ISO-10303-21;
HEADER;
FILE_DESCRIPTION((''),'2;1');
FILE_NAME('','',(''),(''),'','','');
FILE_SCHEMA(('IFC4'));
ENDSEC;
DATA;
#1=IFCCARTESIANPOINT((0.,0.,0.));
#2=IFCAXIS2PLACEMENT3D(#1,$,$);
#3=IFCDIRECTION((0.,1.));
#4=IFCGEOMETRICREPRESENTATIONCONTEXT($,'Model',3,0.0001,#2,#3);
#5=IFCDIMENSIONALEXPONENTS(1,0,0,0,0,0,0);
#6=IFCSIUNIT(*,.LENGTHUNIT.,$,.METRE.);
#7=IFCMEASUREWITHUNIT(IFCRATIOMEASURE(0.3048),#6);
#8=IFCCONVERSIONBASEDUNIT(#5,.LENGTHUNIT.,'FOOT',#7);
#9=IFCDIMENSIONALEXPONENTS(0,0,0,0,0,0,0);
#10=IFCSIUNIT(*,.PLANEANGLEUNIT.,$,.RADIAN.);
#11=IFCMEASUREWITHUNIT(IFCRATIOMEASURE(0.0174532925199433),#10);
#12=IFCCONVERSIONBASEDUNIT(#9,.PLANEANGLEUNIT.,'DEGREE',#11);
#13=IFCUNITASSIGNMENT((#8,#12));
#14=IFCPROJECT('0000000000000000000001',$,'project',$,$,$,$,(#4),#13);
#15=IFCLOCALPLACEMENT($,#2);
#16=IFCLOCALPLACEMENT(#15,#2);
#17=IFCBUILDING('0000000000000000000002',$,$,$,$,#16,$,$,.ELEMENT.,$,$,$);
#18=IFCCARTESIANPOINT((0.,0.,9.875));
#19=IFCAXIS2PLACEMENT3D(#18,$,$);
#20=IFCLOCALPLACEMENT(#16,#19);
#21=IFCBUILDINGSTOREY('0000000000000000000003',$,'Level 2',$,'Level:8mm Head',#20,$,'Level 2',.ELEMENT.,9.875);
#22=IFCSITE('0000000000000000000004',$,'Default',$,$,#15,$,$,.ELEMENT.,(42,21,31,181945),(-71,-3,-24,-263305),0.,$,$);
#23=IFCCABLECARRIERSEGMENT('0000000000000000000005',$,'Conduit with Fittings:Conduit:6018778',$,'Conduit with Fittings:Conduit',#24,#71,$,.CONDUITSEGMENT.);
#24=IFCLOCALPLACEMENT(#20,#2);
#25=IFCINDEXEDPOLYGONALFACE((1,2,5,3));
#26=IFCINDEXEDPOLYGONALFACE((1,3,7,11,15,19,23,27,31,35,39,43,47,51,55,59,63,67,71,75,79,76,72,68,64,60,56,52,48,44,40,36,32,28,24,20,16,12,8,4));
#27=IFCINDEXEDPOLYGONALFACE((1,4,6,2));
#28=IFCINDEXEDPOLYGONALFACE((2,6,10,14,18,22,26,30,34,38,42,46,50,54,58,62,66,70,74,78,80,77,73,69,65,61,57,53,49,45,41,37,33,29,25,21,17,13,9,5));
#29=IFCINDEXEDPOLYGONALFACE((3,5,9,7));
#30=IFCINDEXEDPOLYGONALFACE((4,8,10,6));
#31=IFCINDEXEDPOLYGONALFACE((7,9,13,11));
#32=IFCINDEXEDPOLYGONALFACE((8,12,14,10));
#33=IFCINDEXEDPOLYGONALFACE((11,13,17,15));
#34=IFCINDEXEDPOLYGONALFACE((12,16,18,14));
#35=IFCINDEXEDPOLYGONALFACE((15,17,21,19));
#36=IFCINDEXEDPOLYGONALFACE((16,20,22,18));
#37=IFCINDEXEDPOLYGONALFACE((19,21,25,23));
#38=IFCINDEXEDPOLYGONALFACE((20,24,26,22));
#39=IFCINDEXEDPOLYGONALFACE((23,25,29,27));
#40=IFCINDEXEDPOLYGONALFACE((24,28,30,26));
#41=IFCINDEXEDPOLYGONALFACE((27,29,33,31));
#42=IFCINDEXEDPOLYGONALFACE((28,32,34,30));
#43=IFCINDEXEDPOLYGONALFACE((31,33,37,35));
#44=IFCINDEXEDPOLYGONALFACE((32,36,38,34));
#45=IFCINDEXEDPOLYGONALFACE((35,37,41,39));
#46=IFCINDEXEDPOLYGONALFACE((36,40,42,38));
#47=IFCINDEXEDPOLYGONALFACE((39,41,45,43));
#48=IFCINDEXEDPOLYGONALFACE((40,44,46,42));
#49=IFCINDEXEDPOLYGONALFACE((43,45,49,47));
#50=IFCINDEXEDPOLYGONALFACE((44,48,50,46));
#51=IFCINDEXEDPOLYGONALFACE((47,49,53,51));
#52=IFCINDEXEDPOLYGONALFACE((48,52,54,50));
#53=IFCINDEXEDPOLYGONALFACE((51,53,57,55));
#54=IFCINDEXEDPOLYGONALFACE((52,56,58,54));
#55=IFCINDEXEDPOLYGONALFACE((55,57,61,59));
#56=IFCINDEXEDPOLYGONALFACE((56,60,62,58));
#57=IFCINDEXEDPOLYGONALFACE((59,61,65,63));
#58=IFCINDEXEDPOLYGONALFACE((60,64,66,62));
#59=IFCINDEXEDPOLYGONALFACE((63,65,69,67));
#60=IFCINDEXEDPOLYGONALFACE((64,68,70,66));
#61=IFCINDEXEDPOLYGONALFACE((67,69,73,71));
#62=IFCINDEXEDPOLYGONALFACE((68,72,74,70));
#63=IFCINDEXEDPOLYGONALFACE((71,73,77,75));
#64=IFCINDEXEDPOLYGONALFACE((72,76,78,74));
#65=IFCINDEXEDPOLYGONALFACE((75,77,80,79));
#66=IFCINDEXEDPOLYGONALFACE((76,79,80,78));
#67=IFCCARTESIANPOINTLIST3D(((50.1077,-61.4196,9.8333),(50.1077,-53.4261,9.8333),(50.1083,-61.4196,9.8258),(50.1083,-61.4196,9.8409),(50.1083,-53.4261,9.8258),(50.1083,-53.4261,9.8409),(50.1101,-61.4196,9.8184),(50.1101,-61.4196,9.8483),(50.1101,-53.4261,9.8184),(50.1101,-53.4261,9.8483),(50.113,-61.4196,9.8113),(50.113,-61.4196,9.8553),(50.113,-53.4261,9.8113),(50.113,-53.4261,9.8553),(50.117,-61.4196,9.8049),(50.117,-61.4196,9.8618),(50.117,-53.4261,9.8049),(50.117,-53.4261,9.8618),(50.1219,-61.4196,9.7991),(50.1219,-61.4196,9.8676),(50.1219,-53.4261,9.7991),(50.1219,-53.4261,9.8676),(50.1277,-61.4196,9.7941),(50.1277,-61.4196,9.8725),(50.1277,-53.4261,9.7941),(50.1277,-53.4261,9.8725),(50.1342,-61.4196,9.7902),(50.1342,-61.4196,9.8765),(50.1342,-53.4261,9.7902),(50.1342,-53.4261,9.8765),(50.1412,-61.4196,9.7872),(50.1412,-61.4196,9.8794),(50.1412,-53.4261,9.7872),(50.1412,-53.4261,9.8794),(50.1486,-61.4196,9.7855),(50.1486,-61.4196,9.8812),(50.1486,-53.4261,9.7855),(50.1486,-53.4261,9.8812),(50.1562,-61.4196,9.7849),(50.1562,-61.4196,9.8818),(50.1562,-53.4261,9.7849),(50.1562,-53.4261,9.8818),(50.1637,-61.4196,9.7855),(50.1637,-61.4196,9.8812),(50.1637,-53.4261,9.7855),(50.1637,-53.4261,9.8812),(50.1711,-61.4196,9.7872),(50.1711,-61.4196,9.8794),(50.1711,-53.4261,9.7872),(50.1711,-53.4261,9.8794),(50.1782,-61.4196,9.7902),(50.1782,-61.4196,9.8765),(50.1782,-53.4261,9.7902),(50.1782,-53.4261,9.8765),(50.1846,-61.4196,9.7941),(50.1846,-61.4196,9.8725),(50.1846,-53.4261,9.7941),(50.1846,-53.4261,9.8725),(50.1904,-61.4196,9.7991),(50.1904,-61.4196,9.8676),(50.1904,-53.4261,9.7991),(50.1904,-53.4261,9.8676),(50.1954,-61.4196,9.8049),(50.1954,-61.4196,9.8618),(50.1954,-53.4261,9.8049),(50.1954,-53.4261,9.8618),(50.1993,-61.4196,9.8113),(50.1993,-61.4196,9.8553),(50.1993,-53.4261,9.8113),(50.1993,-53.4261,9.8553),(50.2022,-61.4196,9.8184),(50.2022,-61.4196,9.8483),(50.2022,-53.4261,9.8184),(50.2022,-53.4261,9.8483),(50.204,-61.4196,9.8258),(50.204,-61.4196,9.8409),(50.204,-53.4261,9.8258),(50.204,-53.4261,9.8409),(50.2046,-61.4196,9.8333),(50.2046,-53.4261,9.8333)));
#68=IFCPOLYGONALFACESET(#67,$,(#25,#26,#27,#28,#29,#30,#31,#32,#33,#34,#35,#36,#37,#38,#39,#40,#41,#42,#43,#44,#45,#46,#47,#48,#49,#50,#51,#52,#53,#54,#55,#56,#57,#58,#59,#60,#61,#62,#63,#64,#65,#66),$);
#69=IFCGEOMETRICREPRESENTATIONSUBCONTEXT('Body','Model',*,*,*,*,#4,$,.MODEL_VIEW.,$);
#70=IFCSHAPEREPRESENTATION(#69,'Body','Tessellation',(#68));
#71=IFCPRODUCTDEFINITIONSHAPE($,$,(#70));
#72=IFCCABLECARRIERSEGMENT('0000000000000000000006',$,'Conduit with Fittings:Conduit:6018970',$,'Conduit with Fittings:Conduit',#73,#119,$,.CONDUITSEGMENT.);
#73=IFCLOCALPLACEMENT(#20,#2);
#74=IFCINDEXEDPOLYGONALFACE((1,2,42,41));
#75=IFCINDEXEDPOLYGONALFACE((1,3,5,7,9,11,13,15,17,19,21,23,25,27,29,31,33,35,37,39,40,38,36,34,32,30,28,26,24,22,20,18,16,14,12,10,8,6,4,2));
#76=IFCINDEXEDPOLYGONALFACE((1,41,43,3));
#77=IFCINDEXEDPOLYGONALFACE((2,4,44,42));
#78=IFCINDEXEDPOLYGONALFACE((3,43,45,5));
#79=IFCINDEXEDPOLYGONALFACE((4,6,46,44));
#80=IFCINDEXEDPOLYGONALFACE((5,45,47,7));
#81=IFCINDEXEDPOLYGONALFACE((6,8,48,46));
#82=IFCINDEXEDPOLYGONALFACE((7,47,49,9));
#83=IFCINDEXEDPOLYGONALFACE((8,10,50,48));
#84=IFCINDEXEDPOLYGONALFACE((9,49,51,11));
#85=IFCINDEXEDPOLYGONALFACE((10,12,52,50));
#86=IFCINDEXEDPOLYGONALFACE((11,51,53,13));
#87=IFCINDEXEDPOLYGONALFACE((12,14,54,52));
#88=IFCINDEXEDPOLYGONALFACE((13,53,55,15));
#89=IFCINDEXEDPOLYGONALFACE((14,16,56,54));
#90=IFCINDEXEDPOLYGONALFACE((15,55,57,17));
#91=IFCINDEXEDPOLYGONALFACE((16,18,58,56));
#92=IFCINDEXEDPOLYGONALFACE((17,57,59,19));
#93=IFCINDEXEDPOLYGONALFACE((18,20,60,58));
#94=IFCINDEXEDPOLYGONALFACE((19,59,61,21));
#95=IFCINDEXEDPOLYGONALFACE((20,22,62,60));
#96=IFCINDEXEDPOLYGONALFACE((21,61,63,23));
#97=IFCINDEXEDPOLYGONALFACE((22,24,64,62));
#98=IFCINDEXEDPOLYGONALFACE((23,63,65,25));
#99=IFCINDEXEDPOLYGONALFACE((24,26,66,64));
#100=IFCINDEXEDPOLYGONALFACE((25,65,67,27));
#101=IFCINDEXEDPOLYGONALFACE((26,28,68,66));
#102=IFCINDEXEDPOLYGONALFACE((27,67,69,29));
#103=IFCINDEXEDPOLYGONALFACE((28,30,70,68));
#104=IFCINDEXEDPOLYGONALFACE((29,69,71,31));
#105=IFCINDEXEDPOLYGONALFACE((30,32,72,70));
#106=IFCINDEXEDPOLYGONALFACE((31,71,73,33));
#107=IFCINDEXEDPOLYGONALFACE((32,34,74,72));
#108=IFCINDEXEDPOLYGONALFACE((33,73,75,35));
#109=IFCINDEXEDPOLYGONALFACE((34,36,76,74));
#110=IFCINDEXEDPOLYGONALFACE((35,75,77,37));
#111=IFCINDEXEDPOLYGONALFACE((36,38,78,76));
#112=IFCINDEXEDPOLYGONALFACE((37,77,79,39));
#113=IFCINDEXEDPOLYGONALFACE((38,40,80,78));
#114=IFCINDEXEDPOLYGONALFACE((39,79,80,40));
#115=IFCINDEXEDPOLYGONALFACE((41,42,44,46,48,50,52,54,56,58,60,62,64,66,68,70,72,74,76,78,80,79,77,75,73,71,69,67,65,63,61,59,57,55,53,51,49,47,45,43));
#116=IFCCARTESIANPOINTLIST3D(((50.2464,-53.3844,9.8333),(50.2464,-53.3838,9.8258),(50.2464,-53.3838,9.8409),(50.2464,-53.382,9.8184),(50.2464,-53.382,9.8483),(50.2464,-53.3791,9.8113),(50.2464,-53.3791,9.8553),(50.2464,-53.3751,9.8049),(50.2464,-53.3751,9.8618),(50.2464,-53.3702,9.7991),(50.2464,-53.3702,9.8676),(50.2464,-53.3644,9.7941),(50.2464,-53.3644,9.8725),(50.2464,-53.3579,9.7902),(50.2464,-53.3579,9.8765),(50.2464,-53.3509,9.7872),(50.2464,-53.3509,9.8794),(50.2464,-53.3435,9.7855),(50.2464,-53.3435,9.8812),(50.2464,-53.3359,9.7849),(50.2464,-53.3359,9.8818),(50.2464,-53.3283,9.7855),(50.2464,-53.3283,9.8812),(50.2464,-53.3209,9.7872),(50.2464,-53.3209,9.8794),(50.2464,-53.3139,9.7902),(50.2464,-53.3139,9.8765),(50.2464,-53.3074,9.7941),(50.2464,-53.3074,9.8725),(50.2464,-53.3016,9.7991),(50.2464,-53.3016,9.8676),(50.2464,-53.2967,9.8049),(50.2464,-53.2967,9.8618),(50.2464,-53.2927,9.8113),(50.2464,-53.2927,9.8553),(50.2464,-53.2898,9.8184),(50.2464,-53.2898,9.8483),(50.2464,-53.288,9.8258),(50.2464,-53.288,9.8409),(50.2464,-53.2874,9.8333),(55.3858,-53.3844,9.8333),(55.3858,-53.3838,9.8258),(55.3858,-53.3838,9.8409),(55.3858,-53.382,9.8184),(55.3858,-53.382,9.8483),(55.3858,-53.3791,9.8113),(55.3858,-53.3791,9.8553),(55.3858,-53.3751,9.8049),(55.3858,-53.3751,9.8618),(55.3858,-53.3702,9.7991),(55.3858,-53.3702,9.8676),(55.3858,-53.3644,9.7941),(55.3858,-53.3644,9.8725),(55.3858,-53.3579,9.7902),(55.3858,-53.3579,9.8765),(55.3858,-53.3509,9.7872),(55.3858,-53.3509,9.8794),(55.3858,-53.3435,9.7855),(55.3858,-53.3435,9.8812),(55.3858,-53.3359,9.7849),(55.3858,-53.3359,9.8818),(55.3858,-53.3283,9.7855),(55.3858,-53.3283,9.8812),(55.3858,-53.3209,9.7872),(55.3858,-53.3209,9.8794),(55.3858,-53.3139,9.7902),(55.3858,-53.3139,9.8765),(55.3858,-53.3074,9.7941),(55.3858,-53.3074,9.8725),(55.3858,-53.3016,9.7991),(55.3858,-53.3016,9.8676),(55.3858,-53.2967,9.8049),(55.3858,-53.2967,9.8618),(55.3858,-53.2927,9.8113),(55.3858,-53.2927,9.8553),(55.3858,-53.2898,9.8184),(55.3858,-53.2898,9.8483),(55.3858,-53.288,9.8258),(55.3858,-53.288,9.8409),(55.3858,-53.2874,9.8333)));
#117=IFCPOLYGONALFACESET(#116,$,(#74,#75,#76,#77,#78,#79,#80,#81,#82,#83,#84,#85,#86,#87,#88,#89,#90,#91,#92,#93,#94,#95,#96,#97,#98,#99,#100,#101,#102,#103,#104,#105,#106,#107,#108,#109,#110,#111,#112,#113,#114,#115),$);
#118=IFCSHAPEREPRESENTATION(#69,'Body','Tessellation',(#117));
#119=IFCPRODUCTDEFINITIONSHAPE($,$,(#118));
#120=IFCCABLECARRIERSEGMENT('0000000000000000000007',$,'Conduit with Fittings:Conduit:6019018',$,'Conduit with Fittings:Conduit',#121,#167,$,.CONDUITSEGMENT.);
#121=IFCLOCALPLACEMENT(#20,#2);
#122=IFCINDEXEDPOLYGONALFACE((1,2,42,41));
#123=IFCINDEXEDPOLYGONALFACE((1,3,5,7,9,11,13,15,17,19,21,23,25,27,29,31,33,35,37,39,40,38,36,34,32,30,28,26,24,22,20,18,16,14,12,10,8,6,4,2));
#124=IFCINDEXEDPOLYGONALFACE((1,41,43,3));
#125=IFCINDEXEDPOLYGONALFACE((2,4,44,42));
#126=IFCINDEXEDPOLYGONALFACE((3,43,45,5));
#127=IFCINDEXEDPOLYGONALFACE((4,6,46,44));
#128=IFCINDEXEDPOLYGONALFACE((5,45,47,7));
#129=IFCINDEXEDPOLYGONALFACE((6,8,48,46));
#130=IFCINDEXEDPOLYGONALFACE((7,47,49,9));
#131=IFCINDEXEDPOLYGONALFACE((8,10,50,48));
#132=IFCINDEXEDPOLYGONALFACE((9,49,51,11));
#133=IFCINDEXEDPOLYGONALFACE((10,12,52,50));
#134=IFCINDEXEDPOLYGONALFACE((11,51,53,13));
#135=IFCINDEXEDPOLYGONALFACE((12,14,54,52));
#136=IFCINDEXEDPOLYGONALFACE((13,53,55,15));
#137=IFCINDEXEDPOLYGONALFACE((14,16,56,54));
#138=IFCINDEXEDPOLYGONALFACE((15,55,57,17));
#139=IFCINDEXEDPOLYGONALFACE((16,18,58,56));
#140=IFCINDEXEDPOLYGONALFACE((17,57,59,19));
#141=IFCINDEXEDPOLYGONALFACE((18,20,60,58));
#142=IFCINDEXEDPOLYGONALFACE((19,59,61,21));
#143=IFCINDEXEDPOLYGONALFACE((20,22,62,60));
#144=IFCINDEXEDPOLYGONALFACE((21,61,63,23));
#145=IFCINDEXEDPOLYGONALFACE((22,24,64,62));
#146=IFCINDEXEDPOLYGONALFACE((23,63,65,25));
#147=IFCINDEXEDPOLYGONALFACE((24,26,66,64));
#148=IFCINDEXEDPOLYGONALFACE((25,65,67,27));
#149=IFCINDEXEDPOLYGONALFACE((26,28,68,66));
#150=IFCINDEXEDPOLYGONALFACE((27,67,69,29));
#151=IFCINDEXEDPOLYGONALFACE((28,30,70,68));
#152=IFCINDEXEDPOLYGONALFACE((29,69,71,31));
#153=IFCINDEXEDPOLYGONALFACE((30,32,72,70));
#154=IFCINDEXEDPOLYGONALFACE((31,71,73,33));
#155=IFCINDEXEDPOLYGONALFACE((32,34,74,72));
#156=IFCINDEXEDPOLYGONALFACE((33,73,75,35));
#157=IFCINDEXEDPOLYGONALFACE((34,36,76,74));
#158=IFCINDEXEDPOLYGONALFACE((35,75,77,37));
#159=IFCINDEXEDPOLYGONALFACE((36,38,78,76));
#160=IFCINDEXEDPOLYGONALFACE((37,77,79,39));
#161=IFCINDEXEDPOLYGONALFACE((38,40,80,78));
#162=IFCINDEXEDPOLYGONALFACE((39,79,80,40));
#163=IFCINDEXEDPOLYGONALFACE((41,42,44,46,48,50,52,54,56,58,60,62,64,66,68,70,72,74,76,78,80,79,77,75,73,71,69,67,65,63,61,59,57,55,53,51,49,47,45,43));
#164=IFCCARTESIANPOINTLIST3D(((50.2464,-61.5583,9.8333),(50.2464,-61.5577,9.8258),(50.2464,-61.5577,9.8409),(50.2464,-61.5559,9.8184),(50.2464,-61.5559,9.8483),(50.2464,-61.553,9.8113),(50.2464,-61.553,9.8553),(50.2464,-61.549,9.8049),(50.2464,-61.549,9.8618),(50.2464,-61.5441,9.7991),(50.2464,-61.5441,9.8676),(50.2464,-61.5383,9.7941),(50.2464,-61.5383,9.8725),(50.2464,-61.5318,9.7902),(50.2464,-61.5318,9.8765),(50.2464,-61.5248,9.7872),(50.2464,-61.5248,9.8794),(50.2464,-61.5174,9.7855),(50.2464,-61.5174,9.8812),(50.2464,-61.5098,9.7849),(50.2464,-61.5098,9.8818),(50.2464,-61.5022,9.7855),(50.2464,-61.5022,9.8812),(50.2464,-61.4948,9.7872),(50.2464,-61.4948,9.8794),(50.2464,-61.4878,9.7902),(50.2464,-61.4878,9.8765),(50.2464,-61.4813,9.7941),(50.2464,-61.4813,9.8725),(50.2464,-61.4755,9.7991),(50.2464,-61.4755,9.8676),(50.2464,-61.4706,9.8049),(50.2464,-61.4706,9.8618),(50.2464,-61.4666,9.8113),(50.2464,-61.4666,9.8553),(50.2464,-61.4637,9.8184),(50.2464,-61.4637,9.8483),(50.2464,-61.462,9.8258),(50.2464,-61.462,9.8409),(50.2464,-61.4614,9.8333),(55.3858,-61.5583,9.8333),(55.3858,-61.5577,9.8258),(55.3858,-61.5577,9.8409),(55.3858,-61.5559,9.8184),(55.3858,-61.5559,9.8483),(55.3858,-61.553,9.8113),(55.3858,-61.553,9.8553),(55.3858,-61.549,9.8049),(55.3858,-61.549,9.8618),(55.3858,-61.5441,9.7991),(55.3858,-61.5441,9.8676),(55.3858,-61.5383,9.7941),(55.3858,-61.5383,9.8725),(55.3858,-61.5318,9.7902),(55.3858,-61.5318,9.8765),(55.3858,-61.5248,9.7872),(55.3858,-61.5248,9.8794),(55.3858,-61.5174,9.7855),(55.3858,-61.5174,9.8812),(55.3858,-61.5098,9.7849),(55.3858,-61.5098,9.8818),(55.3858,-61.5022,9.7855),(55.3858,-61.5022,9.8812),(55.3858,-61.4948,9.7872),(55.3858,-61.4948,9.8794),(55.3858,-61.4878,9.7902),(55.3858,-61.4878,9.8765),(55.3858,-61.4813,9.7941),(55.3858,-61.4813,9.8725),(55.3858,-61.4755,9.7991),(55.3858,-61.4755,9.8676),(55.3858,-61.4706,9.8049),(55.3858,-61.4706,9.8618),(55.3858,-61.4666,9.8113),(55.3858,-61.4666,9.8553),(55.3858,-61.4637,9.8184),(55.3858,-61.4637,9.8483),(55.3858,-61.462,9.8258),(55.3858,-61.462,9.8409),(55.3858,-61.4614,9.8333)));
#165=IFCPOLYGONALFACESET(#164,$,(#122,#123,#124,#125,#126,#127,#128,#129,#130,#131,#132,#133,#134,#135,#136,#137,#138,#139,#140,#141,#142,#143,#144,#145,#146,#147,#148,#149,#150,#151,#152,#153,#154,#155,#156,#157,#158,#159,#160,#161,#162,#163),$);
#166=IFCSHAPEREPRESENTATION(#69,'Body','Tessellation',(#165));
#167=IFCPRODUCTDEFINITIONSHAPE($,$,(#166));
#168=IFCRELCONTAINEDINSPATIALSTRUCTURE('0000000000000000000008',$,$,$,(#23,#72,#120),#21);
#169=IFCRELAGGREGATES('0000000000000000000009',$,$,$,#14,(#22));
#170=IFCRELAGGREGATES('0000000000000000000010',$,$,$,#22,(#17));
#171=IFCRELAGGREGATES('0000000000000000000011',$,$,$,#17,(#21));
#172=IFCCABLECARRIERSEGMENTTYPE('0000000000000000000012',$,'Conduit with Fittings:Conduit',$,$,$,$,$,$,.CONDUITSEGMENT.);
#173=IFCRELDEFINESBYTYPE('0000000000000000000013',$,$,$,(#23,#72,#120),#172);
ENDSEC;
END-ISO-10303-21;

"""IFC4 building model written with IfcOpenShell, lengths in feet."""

from ifc_helpers import new_model, entity, si_unit, converted_unit, direction, frame, origin, place, context, subcontext, project, spatial, indexed_curve, outline, extrude, type_object, element, save


model = new_model("IFC4")

# Units and contexts
model_context = context("Model", 3, precision=0.0001, world=origin(), true_north=direction((0.0, 1.0)))
body_context = subcontext(model_context, "Body", "Model", "MODEL_VIEW")
ifc_project = project(units=[converted_unit("LENGTHUNIT", "FOOT", entity("IfcRatioMeasure", 0.3048), si_unit("LENGTHUNIT", "METRE"), dimensions=[1, 0, 0, 0, 0, 0, 0]), converted_unit("PLANEANGLEUNIT", "DEGREE", entity("IfcRatioMeasure", 0.0174532925199433), si_unit("PLANEANGLEUNIT", "RADIAN"), dimensions=[0, 0, 0, 0, 0, 0, 0])], contexts=[model_context])

# Site, building, storey
site_placement = place(None, origin())
site = spatial("IfcSite", under=ifc_project, at=site_placement, Name="Default", CompositionType="ELEMENT", RefLatitude=(42, 21, 31, 181945), RefLongitude=(-71, -3, -24, -263305), RefElevation=0.0)
building_placement = place(site_placement, origin())
building = spatial("IfcBuilding", under=site, at=building_placement, CompositionType="ELEMENT")
storey_placement = place(building_placement, frame((0.0, 0.0, 9.875)))
storey = spatial("IfcBuildingStorey", under=building, at=storey_placement, Name="Level 2", ObjectType="Level:8mm Head", LongName="Level 2", CompositionType="ELEMENT", Elevation=9.875)

# Cable carrier segments
cable_carrier_segment_type = type_object("IfcCableCarrierSegmentType", Name="Conduit with Fittings:Conduit", PredefinedType="CONDUITSEGMENT")
cable_carrier_segment_1_placement = place(storey_placement, origin())
element("IfcCableCarrierSegment", 1, at=cable_carrier_segment_1_placement, inside=storey, type_object=cable_carrier_segment_type, Name="Conduit with Fittings:Conduit:6018778", ObjectType="Conduit with Fittings:Conduit", PredefinedType="CONDUITSEGMENT", context=body_context, shape_type="SweptSolid", body=[
    extrude(outline(indexed_curve([(0.0485, 0.0), (0.0479, 0.0076), (0.0461, 0.015), (0.0432, 0.022), (0.0392, 0.0285), (0.0343, 0.0343), (0.0285, 0.0392), (0.022, 0.0432), (0.015, 0.0461), (0.0076, 0.0479), (0.0, 0.0485), (-0.0076, 0.0479), (-0.015, 0.0461), (-0.022, 0.0432), (-0.0285, 0.0392), (-0.0343, 0.0343), (-0.0392, 0.0285), (-0.0432, 0.022), (-0.0461, 0.015), (-0.0479, 0.0076), (-0.0485, 0.0), (-0.0479, -0.0076), (-0.0461, -0.015), (-0.0432, -0.022), (-0.0392, -0.0285), (-0.0343, -0.0343), (-0.0285, -0.0392), (-0.022, -0.0432), (-0.015, -0.0461), (-0.0076, -0.0479), (0.0, -0.0485), (0.0076, -0.0479), (0.015, -0.0461), (0.022, -0.0432), (0.0285, -0.0392), (0.0343, -0.0343), (0.0392, -0.0285), (0.0432, -0.022), (0.0461, -0.015), (0.0479, -0.0076), (0.0485, 0.0)], self_intersect=False)), frame((50.1562, -61.4196, 9.8333), z_axis=(0.0, 1.0, 0.0), x_axis=(1.0, 0.0, 0.0)), (0.0, 0.0, 1.0), 7.9935),
])
cable_carrier_segment_2_placement = place(storey_placement, origin())
element("IfcCableCarrierSegment", 2, at=cable_carrier_segment_2_placement, inside=storey, type_object=cable_carrier_segment_type, Name="Conduit with Fittings:Conduit:6018970", ObjectType="Conduit with Fittings:Conduit", PredefinedType="CONDUITSEGMENT", context=body_context, shape_type="SweptSolid", body=[
    extrude(outline(indexed_curve([(0.0485, 0.0), (0.0479, 0.0076), (0.0461, 0.015), (0.0432, 0.022), (0.0392, 0.0285), (0.0343, 0.0343), (0.0285, 0.0392), (0.022, 0.0432), (0.015, 0.0461), (0.0076, 0.0479), (0.0, 0.0485), (-0.0076, 0.0479), (-0.015, 0.0461), (-0.022, 0.0432), (-0.0285, 0.0392), (-0.0343, 0.0343), (-0.0392, 0.0285), (-0.0432, 0.022), (-0.0461, 0.015), (-0.0479, 0.0076), (-0.0485, 0.0), (-0.0479, -0.0076), (-0.0461, -0.015), (-0.0432, -0.022), (-0.0392, -0.0285), (-0.0343, -0.0343), (-0.0285, -0.0392), (-0.022, -0.0432), (-0.015, -0.0461), (-0.0076, -0.0479), (0.0, -0.0485), (0.0076, -0.0479), (0.015, -0.0461), (0.022, -0.0432), (0.0285, -0.0392), (0.0343, -0.0343), (0.0392, -0.0285), (0.0432, -0.022), (0.0461, -0.015), (0.0479, -0.0076), (0.0485, 0.0)], self_intersect=False)), frame((50.2464, -53.3359, 9.8333), z_axis=(1.0, 0.0, 0.0), x_axis=(0.0, -1.0, 0.0)), (0.0, 0.0, 1.0), 5.1394),
])
cable_carrier_segment_3_placement = place(storey_placement, origin())
element("IfcCableCarrierSegment", 3, at=cable_carrier_segment_3_placement, inside=storey, type_object=cable_carrier_segment_type, Name="Conduit with Fittings:Conduit:6019018", ObjectType="Conduit with Fittings:Conduit", PredefinedType="CONDUITSEGMENT", context=body_context, shape_type="SweptSolid", body=[
    extrude(outline(indexed_curve([(0.0485, 0.0), (0.0479, 0.0076), (0.0461, 0.015), (0.0432, 0.022), (0.0392, 0.0285), (0.0343, 0.0343), (0.0285, 0.0392), (0.022, 0.0432), (0.015, 0.0461), (0.0076, 0.0479), (0.0, 0.0485), (-0.0076, 0.0479), (-0.015, 0.0461), (-0.022, 0.0432), (-0.0285, 0.0392), (-0.0343, 0.0343), (-0.0392, 0.0285), (-0.0432, 0.022), (-0.0461, 0.015), (-0.0479, 0.0076), (-0.0485, 0.0), (-0.0479, -0.0076), (-0.0461, -0.015), (-0.0432, -0.022), (-0.0392, -0.0285), (-0.0343, -0.0343), (-0.0285, -0.0392), (-0.022, -0.0432), (-0.015, -0.0461), (-0.0076, -0.0479), (0.0, -0.0485), (0.0076, -0.0479), (0.015, -0.0461), (0.022, -0.0432), (0.0285, -0.0392), (0.0343, -0.0343), (0.0392, -0.0285), (0.0432, -0.022), (0.0461, -0.015), (0.0479, -0.0076), (0.0485, 0.0)], self_intersect=False)), frame((50.2464, -61.5098, 9.8333), z_axis=(1.0, 0.0, 0.0), x_axis=(0.0, -1.0, 0.0)), (0.0, 0.0, 1.0), 5.1394),
])

save(model, "model.ifc")
